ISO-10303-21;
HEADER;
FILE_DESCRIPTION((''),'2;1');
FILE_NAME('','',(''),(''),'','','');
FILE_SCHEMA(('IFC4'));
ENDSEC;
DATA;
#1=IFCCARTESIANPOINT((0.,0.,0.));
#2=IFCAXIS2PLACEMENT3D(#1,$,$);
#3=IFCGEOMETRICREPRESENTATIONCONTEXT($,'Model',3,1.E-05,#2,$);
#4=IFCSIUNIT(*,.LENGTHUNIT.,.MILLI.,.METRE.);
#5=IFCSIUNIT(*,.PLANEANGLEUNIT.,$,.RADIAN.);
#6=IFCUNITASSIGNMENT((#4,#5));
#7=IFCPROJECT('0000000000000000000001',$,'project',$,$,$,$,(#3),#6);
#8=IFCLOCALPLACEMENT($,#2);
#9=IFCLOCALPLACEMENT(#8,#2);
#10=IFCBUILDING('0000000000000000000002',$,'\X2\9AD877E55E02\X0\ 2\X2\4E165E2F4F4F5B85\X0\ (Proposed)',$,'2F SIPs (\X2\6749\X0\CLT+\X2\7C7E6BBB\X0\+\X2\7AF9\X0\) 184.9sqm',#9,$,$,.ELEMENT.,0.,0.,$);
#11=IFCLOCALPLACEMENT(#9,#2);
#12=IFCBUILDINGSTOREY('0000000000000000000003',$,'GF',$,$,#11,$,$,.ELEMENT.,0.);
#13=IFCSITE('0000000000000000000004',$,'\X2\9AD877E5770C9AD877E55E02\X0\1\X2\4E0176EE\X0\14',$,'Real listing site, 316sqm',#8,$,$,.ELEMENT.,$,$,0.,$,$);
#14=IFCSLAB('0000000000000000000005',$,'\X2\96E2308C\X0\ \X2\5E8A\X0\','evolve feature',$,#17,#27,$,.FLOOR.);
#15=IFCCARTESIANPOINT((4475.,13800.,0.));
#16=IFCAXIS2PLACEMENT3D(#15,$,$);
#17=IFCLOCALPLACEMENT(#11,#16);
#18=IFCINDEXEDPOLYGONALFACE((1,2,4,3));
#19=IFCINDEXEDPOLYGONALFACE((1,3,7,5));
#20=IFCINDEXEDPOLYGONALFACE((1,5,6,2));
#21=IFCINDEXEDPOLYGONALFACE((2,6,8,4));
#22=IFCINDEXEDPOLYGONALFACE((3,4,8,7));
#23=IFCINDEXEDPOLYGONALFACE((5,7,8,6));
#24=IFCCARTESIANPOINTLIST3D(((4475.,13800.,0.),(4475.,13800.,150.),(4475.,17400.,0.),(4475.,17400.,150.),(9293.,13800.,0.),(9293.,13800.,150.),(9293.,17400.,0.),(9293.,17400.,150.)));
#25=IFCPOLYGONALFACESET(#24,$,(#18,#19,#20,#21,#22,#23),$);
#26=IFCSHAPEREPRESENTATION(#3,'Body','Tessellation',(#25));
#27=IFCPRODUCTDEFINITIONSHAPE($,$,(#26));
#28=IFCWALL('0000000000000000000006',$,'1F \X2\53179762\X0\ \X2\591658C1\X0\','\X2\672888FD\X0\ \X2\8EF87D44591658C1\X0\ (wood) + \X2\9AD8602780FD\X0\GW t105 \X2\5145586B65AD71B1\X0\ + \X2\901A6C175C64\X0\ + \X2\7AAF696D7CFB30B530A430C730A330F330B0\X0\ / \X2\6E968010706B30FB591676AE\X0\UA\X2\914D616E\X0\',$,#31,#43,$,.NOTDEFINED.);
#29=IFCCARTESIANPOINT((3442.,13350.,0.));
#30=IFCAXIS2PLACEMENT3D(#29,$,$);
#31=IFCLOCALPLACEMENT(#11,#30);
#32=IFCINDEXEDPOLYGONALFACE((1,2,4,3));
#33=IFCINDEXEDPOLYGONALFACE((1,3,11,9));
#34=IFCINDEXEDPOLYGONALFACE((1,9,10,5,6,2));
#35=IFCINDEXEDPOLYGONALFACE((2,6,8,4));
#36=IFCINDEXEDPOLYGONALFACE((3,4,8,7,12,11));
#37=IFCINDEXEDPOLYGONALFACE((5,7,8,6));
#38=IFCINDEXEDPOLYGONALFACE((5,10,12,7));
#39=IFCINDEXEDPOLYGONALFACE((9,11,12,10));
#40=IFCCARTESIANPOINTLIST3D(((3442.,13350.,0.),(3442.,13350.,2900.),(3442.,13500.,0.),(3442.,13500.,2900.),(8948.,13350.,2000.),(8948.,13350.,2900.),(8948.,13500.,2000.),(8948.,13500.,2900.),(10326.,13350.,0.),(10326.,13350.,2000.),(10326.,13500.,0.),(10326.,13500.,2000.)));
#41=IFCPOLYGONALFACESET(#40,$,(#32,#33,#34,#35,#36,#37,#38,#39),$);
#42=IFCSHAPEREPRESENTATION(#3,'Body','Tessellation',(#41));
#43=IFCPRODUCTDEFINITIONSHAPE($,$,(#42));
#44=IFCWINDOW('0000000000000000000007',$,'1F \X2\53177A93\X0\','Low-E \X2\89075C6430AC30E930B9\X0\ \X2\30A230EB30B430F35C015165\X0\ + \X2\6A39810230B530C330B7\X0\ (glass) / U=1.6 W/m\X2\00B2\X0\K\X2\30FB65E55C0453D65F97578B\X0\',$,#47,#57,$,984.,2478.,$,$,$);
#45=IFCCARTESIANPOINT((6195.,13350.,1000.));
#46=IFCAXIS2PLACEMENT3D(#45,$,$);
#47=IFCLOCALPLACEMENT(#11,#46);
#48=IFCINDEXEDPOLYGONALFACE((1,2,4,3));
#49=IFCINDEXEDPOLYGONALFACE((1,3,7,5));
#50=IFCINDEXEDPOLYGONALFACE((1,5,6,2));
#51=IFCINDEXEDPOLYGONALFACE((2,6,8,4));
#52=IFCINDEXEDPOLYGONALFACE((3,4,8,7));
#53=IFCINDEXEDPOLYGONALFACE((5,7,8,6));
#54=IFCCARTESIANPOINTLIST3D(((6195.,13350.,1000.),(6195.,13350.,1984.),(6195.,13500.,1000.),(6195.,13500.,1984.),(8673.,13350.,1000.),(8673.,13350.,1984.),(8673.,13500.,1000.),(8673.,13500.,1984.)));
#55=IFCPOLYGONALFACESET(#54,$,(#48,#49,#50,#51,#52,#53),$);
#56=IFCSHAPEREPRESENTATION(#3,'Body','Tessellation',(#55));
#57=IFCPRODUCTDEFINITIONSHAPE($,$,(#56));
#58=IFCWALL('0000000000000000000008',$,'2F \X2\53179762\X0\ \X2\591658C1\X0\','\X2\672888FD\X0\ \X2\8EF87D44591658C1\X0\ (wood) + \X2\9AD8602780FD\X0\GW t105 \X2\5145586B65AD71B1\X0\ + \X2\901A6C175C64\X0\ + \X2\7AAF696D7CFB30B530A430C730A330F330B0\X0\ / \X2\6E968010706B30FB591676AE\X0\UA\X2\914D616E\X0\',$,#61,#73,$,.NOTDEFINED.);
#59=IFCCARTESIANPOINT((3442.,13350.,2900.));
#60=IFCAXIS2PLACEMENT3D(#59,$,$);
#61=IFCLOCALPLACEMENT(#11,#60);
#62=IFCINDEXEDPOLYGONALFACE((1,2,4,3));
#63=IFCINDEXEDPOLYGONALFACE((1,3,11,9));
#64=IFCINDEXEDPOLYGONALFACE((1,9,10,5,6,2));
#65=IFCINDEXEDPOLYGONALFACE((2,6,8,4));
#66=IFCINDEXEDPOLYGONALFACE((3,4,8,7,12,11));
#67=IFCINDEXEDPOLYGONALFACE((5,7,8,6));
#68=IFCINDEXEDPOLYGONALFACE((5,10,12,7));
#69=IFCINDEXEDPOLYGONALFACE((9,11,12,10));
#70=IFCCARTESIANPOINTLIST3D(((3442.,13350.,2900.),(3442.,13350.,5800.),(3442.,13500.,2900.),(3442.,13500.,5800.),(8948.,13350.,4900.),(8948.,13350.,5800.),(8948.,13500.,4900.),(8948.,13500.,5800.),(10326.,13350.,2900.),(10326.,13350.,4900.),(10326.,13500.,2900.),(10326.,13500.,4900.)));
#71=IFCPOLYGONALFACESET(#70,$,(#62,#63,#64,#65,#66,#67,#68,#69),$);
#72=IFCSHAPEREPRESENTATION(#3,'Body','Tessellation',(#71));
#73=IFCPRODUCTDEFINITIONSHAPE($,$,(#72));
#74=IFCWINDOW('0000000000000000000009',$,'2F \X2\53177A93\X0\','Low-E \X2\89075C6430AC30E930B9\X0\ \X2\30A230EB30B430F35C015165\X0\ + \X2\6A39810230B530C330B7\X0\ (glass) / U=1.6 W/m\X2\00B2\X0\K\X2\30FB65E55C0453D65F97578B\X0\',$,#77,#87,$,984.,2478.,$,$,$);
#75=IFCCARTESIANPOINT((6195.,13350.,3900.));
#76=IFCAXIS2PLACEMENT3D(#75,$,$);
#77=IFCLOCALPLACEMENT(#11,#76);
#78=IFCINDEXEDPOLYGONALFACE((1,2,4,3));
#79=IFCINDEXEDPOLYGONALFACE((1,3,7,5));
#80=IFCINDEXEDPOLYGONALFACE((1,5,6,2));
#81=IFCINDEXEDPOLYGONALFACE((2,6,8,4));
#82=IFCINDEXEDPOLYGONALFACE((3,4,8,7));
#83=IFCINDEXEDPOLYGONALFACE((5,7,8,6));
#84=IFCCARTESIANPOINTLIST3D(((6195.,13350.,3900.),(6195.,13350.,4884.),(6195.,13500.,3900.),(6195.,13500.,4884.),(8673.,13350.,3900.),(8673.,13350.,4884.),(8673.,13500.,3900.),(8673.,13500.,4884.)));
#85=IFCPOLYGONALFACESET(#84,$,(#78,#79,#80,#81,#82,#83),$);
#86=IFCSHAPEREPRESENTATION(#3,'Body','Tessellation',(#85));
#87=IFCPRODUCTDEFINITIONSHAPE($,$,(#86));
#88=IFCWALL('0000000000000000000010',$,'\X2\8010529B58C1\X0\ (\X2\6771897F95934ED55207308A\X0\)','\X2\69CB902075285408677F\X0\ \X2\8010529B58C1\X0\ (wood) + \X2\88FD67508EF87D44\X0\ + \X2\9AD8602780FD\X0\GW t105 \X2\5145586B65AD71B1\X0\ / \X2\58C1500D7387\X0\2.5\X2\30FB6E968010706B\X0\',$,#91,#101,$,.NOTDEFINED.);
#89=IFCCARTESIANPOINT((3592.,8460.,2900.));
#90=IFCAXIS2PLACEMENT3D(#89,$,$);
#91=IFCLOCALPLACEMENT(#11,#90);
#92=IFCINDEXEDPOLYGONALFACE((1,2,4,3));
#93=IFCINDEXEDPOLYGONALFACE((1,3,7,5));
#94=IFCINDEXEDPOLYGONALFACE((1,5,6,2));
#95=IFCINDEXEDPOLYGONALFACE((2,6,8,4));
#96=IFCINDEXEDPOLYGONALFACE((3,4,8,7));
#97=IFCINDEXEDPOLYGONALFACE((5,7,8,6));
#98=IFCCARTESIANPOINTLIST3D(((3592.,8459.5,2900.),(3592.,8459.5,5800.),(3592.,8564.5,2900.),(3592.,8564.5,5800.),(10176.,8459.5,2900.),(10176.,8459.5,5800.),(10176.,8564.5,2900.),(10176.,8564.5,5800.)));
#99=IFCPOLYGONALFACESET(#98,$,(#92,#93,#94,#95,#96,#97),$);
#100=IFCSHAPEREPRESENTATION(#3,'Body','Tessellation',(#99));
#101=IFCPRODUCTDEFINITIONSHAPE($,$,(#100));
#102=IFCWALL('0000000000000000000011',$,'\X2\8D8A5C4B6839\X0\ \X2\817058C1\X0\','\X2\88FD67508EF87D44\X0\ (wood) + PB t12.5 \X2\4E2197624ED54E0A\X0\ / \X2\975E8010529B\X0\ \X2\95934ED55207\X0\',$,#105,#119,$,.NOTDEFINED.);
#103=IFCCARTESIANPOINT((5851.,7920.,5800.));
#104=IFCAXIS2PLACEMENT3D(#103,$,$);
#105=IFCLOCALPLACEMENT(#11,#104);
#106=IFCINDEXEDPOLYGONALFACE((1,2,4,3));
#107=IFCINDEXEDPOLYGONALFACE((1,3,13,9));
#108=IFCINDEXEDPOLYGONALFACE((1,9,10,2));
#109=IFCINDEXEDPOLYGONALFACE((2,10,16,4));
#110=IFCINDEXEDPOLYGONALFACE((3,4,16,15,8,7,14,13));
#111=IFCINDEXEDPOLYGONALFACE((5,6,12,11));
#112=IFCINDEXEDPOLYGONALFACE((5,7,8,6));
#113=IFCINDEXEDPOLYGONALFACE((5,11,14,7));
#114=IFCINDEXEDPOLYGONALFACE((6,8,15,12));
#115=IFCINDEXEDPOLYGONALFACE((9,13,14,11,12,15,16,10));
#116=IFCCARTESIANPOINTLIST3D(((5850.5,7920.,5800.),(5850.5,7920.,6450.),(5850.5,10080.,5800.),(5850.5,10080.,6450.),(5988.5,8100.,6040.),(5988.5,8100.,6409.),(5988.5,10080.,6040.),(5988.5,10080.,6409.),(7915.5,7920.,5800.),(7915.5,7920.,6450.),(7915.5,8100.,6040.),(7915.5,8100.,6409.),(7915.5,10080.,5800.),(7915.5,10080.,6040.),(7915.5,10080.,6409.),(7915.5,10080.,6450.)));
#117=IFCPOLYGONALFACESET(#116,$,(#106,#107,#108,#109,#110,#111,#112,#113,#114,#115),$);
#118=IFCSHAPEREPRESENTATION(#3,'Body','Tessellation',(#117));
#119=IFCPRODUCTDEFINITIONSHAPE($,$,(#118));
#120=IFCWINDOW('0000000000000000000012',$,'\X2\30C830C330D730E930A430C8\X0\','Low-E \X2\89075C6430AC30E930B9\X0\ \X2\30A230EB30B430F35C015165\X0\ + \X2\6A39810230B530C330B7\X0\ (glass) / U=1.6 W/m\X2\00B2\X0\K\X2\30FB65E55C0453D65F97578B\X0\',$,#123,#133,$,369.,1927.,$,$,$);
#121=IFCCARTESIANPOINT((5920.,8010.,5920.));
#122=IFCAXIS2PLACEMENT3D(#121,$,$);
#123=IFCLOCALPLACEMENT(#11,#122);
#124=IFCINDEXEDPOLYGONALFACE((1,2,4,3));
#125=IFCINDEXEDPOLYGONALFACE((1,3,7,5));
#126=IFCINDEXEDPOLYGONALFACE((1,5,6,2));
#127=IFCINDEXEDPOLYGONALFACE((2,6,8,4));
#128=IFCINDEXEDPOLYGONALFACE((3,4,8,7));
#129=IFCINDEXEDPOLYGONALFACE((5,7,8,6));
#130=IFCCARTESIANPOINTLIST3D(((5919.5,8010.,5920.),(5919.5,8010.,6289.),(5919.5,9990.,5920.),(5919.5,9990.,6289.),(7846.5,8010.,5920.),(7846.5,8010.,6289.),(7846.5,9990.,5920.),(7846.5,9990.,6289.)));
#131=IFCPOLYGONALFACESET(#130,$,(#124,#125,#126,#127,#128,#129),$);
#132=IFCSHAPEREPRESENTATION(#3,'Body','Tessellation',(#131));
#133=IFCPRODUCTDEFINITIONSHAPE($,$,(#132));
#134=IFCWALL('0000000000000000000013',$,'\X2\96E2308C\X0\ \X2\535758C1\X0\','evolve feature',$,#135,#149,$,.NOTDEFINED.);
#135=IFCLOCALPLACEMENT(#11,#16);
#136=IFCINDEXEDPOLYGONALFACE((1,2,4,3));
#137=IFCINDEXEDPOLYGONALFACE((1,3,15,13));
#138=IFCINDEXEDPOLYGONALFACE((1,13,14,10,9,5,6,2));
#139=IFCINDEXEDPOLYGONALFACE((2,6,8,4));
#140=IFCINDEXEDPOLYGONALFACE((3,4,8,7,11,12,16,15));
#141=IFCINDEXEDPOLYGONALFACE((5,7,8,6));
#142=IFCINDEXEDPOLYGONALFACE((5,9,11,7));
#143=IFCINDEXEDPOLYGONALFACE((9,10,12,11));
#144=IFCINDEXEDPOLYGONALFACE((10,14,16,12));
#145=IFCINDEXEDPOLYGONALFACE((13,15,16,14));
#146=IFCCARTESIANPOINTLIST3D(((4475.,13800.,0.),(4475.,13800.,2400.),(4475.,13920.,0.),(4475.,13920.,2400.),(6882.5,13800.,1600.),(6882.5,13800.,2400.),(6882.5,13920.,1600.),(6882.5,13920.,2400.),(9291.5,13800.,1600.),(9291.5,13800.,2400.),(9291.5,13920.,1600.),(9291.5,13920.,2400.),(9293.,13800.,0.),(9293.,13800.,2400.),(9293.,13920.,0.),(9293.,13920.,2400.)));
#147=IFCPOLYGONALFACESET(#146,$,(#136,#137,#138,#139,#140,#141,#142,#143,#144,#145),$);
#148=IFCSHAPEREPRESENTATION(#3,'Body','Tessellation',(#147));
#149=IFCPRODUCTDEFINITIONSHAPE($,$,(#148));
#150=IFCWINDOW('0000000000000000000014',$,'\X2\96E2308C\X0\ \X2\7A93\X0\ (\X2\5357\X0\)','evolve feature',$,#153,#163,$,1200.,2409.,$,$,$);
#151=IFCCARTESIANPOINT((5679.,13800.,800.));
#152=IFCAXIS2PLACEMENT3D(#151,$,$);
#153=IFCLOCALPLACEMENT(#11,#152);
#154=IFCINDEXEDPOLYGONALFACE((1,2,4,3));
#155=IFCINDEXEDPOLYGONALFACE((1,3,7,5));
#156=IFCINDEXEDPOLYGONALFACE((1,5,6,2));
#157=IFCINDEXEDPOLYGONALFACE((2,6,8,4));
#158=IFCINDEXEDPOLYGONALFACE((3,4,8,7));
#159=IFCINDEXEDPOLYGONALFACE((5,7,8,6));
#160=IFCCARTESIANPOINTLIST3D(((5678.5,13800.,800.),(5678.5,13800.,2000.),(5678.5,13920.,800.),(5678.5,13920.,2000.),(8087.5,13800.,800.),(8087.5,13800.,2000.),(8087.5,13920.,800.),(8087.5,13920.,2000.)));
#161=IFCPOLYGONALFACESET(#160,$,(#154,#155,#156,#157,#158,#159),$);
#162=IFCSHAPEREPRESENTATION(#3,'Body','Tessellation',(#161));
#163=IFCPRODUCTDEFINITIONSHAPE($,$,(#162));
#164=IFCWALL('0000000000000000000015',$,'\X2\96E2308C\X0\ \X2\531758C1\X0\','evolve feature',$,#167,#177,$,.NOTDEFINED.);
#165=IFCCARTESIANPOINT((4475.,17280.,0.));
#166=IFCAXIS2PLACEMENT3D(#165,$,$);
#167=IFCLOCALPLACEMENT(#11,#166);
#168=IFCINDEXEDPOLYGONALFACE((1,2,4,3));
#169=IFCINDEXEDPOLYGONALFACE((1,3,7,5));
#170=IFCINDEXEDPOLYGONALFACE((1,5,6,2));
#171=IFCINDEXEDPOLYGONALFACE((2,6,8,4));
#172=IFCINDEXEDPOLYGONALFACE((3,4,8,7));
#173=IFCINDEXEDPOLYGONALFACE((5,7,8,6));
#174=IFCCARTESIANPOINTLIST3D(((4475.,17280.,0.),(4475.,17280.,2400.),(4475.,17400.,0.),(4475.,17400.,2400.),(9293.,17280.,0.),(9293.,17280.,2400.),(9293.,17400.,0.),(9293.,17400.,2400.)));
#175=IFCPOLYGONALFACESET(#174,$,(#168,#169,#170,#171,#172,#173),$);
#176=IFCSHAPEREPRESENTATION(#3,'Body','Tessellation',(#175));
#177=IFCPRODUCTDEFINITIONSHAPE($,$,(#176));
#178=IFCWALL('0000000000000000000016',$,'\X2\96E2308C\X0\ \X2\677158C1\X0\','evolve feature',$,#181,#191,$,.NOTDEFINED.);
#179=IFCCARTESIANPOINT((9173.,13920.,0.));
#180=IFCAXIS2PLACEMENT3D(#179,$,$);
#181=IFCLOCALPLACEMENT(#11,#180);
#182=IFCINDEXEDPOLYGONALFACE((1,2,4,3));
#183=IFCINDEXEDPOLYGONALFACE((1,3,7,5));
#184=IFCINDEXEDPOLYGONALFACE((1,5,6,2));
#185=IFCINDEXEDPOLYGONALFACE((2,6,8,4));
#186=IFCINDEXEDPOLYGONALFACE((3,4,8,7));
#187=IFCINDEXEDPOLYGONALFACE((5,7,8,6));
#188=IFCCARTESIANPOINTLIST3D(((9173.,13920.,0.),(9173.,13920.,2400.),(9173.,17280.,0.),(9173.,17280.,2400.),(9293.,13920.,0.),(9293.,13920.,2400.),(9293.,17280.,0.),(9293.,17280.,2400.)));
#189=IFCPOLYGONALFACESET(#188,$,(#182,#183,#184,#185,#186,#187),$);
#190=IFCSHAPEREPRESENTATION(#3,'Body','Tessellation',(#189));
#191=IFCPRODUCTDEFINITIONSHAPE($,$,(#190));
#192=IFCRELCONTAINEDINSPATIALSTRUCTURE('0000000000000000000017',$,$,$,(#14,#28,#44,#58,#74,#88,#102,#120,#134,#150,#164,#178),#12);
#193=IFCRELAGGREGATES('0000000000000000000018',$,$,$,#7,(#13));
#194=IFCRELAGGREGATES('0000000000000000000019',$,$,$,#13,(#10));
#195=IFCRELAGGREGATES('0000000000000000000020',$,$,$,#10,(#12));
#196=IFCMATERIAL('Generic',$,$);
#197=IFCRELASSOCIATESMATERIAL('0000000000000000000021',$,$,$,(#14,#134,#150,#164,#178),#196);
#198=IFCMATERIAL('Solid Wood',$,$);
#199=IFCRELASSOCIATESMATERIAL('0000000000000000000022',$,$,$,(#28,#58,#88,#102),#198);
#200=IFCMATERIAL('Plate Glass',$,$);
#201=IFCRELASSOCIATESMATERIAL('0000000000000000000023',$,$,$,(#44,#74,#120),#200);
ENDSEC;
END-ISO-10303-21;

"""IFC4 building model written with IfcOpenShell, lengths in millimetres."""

from ifc_helpers import new_model, si_unit, frame, frame_2d, origin, place, context, project, spatial, rectangle, extrude, material, element, fill, save


model = new_model("IFC4")

# Units and contexts
model_context = context("Model", 3, precision=1e-05, world=origin())
ifc_project = project(units=[si_unit("LENGTHUNIT", "METRE", prefix="MILLI"), si_unit("PLANEANGLEUNIT", "RADIAN")], contexts=[model_context])

# Site, building, storey
site_placement = place(None, origin())
site = spatial("IfcSite", under=ifc_project, at=site_placement, Name="高知県高知市1丁目14", ObjectType="Real listing site, 316sqm", CompositionType="ELEMENT", RefElevation=0.0)
building_placement = place(site_placement, origin())
building = spatial("IfcBuilding", under=site, at=building_placement, Name="高知市 2世帯住宅 (Proposed)", ObjectType="2F SIPs (杉CLT+籾殻+竹) 184.9sqm", CompositionType="ELEMENT", ElevationOfRefHeight=0.0, ElevationOfTerrain=0.0)
storey_placement = place(building_placement, origin())
storey = spatial("IfcBuildingStorey", under=building, at=storey_placement, Name="GF", CompositionType="ELEMENT", Elevation=0.0)

# Slab
ifc_material_1 = material(Name="Generic")
slab_placement = place(storey_placement, frame((4475.0, 13800.0, 0.0)))
element("IfcSlab", 1, at=slab_placement, inside=storey, material=ifc_material_1, Name="離れ 床", Description="evolve feature", PredefinedType="FLOOR", context=model_context, shape_type="SweptSolid", body=[
    extrude(rectangle(XDim=4818.0, YDim=3600.0, at=frame_2d((2409.0, 1800.0))), frame((4475.0, 13800.0, 0.0)), (0.0, 0.0, 1.0), 150.0),
])

# Wall, opening, window
ifc_material_2 = material(Name="Solid Wood")
wall_1_placement = place(storey_placement, frame((3442.0, 13350.0, 0.0)))
wall_1 = element("IfcWall", 2, at=wall_1_placement, inside=storey, material=ifc_material_2, Name="1F 北面 外壁", Description="木製 軸組外壁 (wood) + 高性能GW t105 充填断熱 + 通気層 + 窯業系サイディング / 準耐火・外皮UA配慮", PredefinedType="NOTDEFINED", context=model_context, shape_type="SweptSolid", body=[
    extrude(rectangle(XDim=6884.0, YDim=150.0, at=frame_2d((3442.0, 75.0))), frame((3442.0, 13350.0, 0.0)), (0.0, 0.0, 1.0), 2900.0),
])
opening_1_placement = place(storey_placement, frame((6195.0, 13350.0, 1000.0)))
opening_1 = element("IfcOpeningElement", 3, at=opening_1_placement, cuts=wall_1, PredefinedType="NOTDEFINED", context=model_context, shape_type="SweptSolid", body=[
    extrude(rectangle(XDim=2478.0, YDim=150.0, at=frame_2d((1239.0, 75.0))), frame((6195.0, 13350.0, 1000.0)), (0.0, 0.0, 1.0), 984.0),
])
ifc_material_3 = material(Name="Plate Glass")
window_1_placement = place(storey_placement, frame((6195.0, 13350.0, 1000.0)))
window_1 = element("IfcWindow", 4, at=window_1_placement, inside=storey, material=ifc_material_3, Name="1F 北窓", Description="Low-E 複層ガラス アルゴン封入 + 樹脂サッシ (glass) / U=1.6 W/m²K・日射取得型", OverallHeight=984.0, OverallWidth=2478.0, context=model_context, shape_type="SweptSolid", body=[
    extrude(rectangle(XDim=2478.0, YDim=150.0, at=frame_2d((1239.0, 75.0))), frame((6195.0, 13350.0, 1000.0)), (0.0, 0.0, 1.0), 984.0),
])
fill(opening_1, window_1)

# Wall, opening, window
wall_2_placement = place(storey_placement, frame((3442.0, 13350.0, 2900.0)))
wall_2 = element("IfcWall", 5, at=wall_2_placement, inside=storey, material=ifc_material_2, Name="2F 北面 外壁", Description="木製 軸組外壁 (wood) + 高性能GW t105 充填断熱 + 通気層 + 窯業系サイディング / 準耐火・外皮UA配慮", PredefinedType="NOTDEFINED", context=model_context, shape_type="SweptSolid", body=[
    extrude(rectangle(XDim=6884.0, YDim=150.0, at=frame_2d((3442.0, 75.0))), frame((3442.0, 13350.0, 2900.0)), (0.0, 0.0, 1.0), 2900.0),
])
opening_2_placement = place(storey_placement, frame((6195.0, 13350.0, 3900.0)))
opening_2 = element("IfcOpeningElement", 6, at=opening_2_placement, cuts=wall_2, PredefinedType="NOTDEFINED", context=model_context, shape_type="SweptSolid", body=[
    extrude(rectangle(XDim=2478.0, YDim=150.0, at=frame_2d((1239.0, 75.0))), frame((6195.0, 13350.0, 3900.0)), (0.0, 0.0, 1.0), 984.0),
])
window_2_placement = place(storey_placement, frame((6195.0, 13350.0, 3900.0)))
window_2 = element("IfcWindow", 7, at=window_2_placement, inside=storey, material=ifc_material_3, Name="2F 北窓", Description="Low-E 複層ガラス アルゴン封入 + 樹脂サッシ (glass) / U=1.6 W/m²K・日射取得型", OverallHeight=984.0, OverallWidth=2478.0, context=model_context, shape_type="SweptSolid", body=[
    extrude(rectangle(XDim=2478.0, YDim=150.0, at=frame_2d((1239.0, 75.0))), frame((6195.0, 13350.0, 3900.0)), (0.0, 0.0, 1.0), 984.0),
])
fill(opening_2, window_2)

# Wall
wall_3_placement = place(storey_placement, frame((3592.0, 8460.0, 2900.0)))
element("IfcWall", 8, at=wall_3_placement, inside=storey, material=ifc_material_2, Name="耐力壁 (東西間仕切り)", Description="構造用合板 耐力壁 (wood) + 製材軸組 + 高性能GW t105 充填断熱 / 壁倍率2.5・準耐火", PredefinedType="NOTDEFINED", context=model_context, shape_type="SweptSolid", body=[
    extrude(rectangle(XDim=6584.0, YDim=105.0, at=frame_2d((3292.0, 52.0))), frame((3592.0, 8460.0, 2900.0)), (0.0, 0.0, 1.0), 2900.0),
])

# Walls, openings, windows
wall_4_placement = place(storey_placement, frame((5851.0, 7920.0, 5800.0)))
wall_4 = element("IfcWall", 9, at=wall_4_placement, inside=storey, material=ifc_material_2, Name="越屋根 腰壁", Description="製材軸組 (wood) + PB t12.5 両面仕上 / 非耐力 間仕切", PredefinedType="NOTDEFINED", context=model_context, shape_type="SweptSolid", body=[
    extrude(rectangle(XDim=2065.0, YDim=2160.0, at=frame_2d((1032.0, 1080.0))), frame((5851.0, 7920.0, 5800.0)), (0.0, 0.0, 1.0), 650.0),
])
opening_3_placement = place(storey_placement, frame((5920.0, 8010.0, 5920.0)))
opening_3 = element("IfcOpeningElement", 10, at=opening_3_placement, cuts=wall_4, PredefinedType="NOTDEFINED", context=model_context, shape_type="SweptSolid", body=[
    extrude(rectangle(XDim=1927.0, YDim=1980.0, at=frame_2d((963.0, 990.0))), frame((5920.0, 8010.0, 5920.0)), (0.0, 0.0, 1.0), 369.0),
])
window_3_placement = place(storey_placement, frame((5920.0, 8010.0, 5920.0)))
window_3 = element("IfcWindow", 11, at=window_3_placement, inside=storey, material=ifc_material_3, Name="トップライト", Description="Low-E 複層ガラス アルゴン封入 + 樹脂サッシ (glass) / U=1.6 W/m²K・日射取得型", OverallHeight=369.0, OverallWidth=1927.0, context=model_context, shape_type="SweptSolid", body=[
    extrude(rectangle(XDim=1927.0, YDim=1980.0, at=frame_2d((963.0, 990.0))), frame((5920.0, 8010.0, 5920.0)), (0.0, 0.0, 1.0), 369.0),
])
fill(opening_3, window_3)
wall_5_placement = place(storey_placement, frame((4475.0, 13800.0, 0.0)))
wall_5 = element("IfcWall", 12, at=wall_5_placement, inside=storey, material=ifc_material_1, Name="離れ 南壁", Description="evolve feature", PredefinedType="NOTDEFINED", context=model_context, shape_type="SweptSolid", body=[
    extrude(rectangle(XDim=4818.0, YDim=120.0, at=frame_2d((2409.0, 60.0))), frame((4475.0, 13800.0, 0.0)), (0.0, 0.0, 1.0), 2400.0),
])
opening_4_placement = place(storey_placement, frame((5679.0, 13800.0, 800.0)))
opening_4 = element("IfcOpeningElement", 13, at=opening_4_placement, cuts=wall_5, PredefinedType="NOTDEFINED", context=model_context, shape_type="SweptSolid", body=[
    extrude(rectangle(XDim=2409.0, YDim=120.0, at=frame_2d((1204.0, 60.0))), frame((5679.0, 13800.0, 800.0)), (0.0, 0.0, 1.0), 1200.0),
])
window_4_placement = place(storey_placement, frame((5679.0, 13800.0, 800.0)))
window_4 = element("IfcWindow", 14, at=window_4_placement, inside=storey, material=ifc_material_1, Name="離れ 窓 (南)", Description="evolve feature", OverallHeight=1200.0, OverallWidth=2409.0, context=model_context, shape_type="SweptSolid", body=[
    extrude(rectangle(XDim=2409.0, YDim=120.0, at=frame_2d((1204.0, 60.0))), frame((5679.0, 13800.0, 800.0)), (0.0, 0.0, 1.0), 1200.0),
])
fill(opening_4, window_4)

# Walls
wall_6_placement = place(storey_placement, frame((4475.0, 17280.0, 0.0)))
element("IfcWall", 15, at=wall_6_placement, inside=storey, material=ifc_material_1, Name="離れ 北壁", Description="evolve feature", PredefinedType="NOTDEFINED", context=model_context, shape_type="SweptSolid", body=[
    extrude(rectangle(XDim=4818.0, YDim=120.0, at=frame_2d((2409.0, 60.0))), frame((4475.0, 17280.0, 0.0)), (0.0, 0.0, 1.0), 2400.0),
])
wall_7_placement = place(storey_placement, frame((9173.0, 13920.0, 0.0)))
element("IfcWall", 16, at=wall_7_placement, inside=storey, material=ifc_material_1, Name="離れ 東壁", Description="evolve feature", PredefinedType="NOTDEFINED", context=model_context, shape_type="SweptSolid", body=[
    extrude(rectangle(XDim=120.0, YDim=3360.0, at=frame_2d((60.0, 1680.0))), frame((9173.0, 13920.0, 0.0)), (0.0, 0.0, 1.0), 2400.0),
])

save(model, "model.ifc")
